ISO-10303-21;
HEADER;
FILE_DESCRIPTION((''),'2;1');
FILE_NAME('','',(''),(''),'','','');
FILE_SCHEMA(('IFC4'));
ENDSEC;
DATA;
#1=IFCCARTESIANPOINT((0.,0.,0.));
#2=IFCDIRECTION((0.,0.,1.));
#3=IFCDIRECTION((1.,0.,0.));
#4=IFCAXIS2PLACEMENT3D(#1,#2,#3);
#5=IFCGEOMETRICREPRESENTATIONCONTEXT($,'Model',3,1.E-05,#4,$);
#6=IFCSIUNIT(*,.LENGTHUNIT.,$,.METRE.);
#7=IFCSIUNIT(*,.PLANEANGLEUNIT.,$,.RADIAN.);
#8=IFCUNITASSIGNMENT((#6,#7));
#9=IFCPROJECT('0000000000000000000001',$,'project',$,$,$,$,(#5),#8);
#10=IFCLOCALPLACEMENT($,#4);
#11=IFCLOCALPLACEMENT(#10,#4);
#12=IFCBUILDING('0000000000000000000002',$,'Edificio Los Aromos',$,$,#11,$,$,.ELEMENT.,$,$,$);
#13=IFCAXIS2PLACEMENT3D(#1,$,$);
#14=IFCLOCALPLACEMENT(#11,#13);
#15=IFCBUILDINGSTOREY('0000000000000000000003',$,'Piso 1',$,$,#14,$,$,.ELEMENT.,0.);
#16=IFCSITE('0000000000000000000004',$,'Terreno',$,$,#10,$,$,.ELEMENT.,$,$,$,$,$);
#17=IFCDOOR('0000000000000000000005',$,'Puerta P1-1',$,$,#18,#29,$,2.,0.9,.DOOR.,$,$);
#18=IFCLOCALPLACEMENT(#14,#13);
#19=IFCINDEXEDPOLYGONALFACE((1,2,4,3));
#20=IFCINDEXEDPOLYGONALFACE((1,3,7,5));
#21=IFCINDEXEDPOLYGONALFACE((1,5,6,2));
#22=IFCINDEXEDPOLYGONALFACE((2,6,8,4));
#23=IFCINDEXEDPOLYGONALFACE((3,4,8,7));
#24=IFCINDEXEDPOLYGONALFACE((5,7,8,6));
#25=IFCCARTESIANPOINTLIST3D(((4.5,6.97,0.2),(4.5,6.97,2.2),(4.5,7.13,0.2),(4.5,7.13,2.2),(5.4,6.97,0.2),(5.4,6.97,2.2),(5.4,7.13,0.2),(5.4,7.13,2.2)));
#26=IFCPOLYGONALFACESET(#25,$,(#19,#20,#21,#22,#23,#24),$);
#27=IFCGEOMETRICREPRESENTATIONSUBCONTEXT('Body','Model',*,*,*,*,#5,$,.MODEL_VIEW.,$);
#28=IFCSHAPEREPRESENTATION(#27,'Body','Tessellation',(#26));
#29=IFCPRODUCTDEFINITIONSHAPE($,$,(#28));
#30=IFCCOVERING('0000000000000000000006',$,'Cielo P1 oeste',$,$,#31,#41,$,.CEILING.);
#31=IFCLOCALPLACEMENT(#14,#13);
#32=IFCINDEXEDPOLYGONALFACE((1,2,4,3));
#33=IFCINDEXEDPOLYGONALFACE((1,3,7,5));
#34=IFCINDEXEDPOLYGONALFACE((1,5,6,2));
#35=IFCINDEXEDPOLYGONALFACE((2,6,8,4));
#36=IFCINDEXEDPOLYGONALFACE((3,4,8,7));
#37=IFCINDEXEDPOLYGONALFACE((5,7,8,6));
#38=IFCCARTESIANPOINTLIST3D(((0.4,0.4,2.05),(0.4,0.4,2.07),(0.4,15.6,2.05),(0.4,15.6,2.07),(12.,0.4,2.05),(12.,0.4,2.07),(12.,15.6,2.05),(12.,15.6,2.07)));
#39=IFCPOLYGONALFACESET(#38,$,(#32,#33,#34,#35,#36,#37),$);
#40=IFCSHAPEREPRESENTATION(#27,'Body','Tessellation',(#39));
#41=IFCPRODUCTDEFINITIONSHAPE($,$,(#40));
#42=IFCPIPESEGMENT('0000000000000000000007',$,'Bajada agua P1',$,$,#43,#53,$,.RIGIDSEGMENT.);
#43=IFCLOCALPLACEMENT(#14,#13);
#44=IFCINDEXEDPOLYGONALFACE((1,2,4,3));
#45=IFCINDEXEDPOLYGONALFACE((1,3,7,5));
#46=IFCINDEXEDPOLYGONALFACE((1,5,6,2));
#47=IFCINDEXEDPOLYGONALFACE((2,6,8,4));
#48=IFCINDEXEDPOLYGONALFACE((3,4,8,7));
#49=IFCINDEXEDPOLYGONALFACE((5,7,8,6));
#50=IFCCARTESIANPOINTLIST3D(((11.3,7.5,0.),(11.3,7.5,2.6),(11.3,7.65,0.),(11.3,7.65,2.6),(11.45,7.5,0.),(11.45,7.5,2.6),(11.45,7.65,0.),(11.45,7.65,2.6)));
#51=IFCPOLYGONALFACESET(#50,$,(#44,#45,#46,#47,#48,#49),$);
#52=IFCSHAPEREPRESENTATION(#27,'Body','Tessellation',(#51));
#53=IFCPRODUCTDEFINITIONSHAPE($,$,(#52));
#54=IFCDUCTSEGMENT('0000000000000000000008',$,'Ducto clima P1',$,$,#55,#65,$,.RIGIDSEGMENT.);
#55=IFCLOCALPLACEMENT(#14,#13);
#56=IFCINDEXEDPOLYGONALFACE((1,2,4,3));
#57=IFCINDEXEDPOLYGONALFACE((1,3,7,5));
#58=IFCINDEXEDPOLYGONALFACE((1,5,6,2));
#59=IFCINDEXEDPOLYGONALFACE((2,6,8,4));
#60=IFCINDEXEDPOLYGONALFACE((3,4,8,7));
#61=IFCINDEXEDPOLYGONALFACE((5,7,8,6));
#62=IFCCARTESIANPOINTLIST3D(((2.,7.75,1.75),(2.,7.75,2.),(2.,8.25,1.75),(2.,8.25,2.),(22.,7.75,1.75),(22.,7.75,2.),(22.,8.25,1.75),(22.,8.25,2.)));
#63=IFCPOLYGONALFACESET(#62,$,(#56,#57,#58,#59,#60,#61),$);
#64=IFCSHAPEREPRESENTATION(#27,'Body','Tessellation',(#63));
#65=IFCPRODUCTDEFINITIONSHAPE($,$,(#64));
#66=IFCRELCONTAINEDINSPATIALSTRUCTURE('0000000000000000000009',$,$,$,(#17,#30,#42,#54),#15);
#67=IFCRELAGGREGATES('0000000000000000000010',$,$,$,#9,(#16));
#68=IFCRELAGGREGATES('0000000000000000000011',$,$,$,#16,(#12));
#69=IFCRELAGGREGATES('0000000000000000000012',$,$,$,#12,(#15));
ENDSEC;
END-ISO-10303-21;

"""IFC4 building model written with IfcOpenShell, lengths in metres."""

from ifc_helpers import new_model, si_unit, frame, frame_2d, origin, origin_with_axes, place, context, subcontext, project, spatial, rectangle, extrude, element, save


model = new_model("IFC4")

# Units and contexts
model_context = context("Model", 3, precision=1e-05, world=origin_with_axes())
body_context = subcontext(model_context, "Body", "Model", "MODEL_VIEW")
ifc_project = project(units=[si_unit("LENGTHUNIT", "METRE"), si_unit("PLANEANGLEUNIT", "RADIAN")], contexts=[model_context])

# Site, building, storey
site_placement = place(None, origin_with_axes())
site = spatial("IfcSite", under=ifc_project, at=site_placement, Name="Terreno", CompositionType="ELEMENT")
building_placement = place(site_placement, origin_with_axes())
building = spatial("IfcBuilding", under=site, at=building_placement, Name="Edificio Los Aromos", CompositionType="ELEMENT")
storey_placement = place(building_placement, origin())
storey = spatial("IfcBuildingStorey", under=building, at=storey_placement, Name="Piso 1", CompositionType="ELEMENT", Elevation=0.0)

# Door
door_placement = place(storey_placement, frame((4.5, 6.97, 0.2)))
element("IfcDoor", 1, at=door_placement, inside=storey, Name="Puerta P1-1", OverallHeight=2.0, OverallWidth=0.9, PredefinedType="DOOR", context=body_context, shape_type="SweptSolid", body=[
    extrude(rectangle(XDim=0.9, YDim=0.16, at=frame_2d((0.45, 0.08))), origin_with_axes(), (0.0, 0.0, 1.0), 2.0),
])

# Covering
covering_placement = place(storey_placement, frame((0.4, 0.4, 2.05)))
element("IfcCovering", 2, at=covering_placement, inside=storey, Name="Cielo P1 oeste", PredefinedType="CEILING", context=body_context, shape_type="SweptSolid", body=[
    extrude(rectangle(XDim=11.6, YDim=15.2, at=frame_2d((5.8, 7.6))), origin_with_axes(), (0.0, 0.0, 1.0), 0.02),
])

# Pipe segment
pipe_segment_placement = place(storey_placement, frame((11.3, 7.5, 0.0)))
element("IfcPipeSegment", 3, at=pipe_segment_placement, inside=storey, Name="Bajada agua P1", PredefinedType="RIGIDSEGMENT", context=body_context, shape_type="SweptSolid", body=[
    extrude(rectangle(XDim=0.15, YDim=0.15, at=frame_2d((0.075, 0.075))), origin_with_axes(), (0.0, 0.0, 1.0), 2.6),
])

# Duct segment
duct_segment_placement = place(storey_placement, frame((2.0, 7.75, 1.75)))
element("IfcDuctSegment", 4, at=duct_segment_placement, inside=storey, Name="Ducto clima P1", PredefinedType="RIGIDSEGMENT", context=body_context, shape_type="SweptSolid", body=[
    extrude(rectangle(XDim=20.0, YDim=0.5, at=frame_2d((10.0, 0.25))), origin_with_axes(), (0.0, 0.0, 1.0), 0.25),
])

save(model, "model.ifc")
